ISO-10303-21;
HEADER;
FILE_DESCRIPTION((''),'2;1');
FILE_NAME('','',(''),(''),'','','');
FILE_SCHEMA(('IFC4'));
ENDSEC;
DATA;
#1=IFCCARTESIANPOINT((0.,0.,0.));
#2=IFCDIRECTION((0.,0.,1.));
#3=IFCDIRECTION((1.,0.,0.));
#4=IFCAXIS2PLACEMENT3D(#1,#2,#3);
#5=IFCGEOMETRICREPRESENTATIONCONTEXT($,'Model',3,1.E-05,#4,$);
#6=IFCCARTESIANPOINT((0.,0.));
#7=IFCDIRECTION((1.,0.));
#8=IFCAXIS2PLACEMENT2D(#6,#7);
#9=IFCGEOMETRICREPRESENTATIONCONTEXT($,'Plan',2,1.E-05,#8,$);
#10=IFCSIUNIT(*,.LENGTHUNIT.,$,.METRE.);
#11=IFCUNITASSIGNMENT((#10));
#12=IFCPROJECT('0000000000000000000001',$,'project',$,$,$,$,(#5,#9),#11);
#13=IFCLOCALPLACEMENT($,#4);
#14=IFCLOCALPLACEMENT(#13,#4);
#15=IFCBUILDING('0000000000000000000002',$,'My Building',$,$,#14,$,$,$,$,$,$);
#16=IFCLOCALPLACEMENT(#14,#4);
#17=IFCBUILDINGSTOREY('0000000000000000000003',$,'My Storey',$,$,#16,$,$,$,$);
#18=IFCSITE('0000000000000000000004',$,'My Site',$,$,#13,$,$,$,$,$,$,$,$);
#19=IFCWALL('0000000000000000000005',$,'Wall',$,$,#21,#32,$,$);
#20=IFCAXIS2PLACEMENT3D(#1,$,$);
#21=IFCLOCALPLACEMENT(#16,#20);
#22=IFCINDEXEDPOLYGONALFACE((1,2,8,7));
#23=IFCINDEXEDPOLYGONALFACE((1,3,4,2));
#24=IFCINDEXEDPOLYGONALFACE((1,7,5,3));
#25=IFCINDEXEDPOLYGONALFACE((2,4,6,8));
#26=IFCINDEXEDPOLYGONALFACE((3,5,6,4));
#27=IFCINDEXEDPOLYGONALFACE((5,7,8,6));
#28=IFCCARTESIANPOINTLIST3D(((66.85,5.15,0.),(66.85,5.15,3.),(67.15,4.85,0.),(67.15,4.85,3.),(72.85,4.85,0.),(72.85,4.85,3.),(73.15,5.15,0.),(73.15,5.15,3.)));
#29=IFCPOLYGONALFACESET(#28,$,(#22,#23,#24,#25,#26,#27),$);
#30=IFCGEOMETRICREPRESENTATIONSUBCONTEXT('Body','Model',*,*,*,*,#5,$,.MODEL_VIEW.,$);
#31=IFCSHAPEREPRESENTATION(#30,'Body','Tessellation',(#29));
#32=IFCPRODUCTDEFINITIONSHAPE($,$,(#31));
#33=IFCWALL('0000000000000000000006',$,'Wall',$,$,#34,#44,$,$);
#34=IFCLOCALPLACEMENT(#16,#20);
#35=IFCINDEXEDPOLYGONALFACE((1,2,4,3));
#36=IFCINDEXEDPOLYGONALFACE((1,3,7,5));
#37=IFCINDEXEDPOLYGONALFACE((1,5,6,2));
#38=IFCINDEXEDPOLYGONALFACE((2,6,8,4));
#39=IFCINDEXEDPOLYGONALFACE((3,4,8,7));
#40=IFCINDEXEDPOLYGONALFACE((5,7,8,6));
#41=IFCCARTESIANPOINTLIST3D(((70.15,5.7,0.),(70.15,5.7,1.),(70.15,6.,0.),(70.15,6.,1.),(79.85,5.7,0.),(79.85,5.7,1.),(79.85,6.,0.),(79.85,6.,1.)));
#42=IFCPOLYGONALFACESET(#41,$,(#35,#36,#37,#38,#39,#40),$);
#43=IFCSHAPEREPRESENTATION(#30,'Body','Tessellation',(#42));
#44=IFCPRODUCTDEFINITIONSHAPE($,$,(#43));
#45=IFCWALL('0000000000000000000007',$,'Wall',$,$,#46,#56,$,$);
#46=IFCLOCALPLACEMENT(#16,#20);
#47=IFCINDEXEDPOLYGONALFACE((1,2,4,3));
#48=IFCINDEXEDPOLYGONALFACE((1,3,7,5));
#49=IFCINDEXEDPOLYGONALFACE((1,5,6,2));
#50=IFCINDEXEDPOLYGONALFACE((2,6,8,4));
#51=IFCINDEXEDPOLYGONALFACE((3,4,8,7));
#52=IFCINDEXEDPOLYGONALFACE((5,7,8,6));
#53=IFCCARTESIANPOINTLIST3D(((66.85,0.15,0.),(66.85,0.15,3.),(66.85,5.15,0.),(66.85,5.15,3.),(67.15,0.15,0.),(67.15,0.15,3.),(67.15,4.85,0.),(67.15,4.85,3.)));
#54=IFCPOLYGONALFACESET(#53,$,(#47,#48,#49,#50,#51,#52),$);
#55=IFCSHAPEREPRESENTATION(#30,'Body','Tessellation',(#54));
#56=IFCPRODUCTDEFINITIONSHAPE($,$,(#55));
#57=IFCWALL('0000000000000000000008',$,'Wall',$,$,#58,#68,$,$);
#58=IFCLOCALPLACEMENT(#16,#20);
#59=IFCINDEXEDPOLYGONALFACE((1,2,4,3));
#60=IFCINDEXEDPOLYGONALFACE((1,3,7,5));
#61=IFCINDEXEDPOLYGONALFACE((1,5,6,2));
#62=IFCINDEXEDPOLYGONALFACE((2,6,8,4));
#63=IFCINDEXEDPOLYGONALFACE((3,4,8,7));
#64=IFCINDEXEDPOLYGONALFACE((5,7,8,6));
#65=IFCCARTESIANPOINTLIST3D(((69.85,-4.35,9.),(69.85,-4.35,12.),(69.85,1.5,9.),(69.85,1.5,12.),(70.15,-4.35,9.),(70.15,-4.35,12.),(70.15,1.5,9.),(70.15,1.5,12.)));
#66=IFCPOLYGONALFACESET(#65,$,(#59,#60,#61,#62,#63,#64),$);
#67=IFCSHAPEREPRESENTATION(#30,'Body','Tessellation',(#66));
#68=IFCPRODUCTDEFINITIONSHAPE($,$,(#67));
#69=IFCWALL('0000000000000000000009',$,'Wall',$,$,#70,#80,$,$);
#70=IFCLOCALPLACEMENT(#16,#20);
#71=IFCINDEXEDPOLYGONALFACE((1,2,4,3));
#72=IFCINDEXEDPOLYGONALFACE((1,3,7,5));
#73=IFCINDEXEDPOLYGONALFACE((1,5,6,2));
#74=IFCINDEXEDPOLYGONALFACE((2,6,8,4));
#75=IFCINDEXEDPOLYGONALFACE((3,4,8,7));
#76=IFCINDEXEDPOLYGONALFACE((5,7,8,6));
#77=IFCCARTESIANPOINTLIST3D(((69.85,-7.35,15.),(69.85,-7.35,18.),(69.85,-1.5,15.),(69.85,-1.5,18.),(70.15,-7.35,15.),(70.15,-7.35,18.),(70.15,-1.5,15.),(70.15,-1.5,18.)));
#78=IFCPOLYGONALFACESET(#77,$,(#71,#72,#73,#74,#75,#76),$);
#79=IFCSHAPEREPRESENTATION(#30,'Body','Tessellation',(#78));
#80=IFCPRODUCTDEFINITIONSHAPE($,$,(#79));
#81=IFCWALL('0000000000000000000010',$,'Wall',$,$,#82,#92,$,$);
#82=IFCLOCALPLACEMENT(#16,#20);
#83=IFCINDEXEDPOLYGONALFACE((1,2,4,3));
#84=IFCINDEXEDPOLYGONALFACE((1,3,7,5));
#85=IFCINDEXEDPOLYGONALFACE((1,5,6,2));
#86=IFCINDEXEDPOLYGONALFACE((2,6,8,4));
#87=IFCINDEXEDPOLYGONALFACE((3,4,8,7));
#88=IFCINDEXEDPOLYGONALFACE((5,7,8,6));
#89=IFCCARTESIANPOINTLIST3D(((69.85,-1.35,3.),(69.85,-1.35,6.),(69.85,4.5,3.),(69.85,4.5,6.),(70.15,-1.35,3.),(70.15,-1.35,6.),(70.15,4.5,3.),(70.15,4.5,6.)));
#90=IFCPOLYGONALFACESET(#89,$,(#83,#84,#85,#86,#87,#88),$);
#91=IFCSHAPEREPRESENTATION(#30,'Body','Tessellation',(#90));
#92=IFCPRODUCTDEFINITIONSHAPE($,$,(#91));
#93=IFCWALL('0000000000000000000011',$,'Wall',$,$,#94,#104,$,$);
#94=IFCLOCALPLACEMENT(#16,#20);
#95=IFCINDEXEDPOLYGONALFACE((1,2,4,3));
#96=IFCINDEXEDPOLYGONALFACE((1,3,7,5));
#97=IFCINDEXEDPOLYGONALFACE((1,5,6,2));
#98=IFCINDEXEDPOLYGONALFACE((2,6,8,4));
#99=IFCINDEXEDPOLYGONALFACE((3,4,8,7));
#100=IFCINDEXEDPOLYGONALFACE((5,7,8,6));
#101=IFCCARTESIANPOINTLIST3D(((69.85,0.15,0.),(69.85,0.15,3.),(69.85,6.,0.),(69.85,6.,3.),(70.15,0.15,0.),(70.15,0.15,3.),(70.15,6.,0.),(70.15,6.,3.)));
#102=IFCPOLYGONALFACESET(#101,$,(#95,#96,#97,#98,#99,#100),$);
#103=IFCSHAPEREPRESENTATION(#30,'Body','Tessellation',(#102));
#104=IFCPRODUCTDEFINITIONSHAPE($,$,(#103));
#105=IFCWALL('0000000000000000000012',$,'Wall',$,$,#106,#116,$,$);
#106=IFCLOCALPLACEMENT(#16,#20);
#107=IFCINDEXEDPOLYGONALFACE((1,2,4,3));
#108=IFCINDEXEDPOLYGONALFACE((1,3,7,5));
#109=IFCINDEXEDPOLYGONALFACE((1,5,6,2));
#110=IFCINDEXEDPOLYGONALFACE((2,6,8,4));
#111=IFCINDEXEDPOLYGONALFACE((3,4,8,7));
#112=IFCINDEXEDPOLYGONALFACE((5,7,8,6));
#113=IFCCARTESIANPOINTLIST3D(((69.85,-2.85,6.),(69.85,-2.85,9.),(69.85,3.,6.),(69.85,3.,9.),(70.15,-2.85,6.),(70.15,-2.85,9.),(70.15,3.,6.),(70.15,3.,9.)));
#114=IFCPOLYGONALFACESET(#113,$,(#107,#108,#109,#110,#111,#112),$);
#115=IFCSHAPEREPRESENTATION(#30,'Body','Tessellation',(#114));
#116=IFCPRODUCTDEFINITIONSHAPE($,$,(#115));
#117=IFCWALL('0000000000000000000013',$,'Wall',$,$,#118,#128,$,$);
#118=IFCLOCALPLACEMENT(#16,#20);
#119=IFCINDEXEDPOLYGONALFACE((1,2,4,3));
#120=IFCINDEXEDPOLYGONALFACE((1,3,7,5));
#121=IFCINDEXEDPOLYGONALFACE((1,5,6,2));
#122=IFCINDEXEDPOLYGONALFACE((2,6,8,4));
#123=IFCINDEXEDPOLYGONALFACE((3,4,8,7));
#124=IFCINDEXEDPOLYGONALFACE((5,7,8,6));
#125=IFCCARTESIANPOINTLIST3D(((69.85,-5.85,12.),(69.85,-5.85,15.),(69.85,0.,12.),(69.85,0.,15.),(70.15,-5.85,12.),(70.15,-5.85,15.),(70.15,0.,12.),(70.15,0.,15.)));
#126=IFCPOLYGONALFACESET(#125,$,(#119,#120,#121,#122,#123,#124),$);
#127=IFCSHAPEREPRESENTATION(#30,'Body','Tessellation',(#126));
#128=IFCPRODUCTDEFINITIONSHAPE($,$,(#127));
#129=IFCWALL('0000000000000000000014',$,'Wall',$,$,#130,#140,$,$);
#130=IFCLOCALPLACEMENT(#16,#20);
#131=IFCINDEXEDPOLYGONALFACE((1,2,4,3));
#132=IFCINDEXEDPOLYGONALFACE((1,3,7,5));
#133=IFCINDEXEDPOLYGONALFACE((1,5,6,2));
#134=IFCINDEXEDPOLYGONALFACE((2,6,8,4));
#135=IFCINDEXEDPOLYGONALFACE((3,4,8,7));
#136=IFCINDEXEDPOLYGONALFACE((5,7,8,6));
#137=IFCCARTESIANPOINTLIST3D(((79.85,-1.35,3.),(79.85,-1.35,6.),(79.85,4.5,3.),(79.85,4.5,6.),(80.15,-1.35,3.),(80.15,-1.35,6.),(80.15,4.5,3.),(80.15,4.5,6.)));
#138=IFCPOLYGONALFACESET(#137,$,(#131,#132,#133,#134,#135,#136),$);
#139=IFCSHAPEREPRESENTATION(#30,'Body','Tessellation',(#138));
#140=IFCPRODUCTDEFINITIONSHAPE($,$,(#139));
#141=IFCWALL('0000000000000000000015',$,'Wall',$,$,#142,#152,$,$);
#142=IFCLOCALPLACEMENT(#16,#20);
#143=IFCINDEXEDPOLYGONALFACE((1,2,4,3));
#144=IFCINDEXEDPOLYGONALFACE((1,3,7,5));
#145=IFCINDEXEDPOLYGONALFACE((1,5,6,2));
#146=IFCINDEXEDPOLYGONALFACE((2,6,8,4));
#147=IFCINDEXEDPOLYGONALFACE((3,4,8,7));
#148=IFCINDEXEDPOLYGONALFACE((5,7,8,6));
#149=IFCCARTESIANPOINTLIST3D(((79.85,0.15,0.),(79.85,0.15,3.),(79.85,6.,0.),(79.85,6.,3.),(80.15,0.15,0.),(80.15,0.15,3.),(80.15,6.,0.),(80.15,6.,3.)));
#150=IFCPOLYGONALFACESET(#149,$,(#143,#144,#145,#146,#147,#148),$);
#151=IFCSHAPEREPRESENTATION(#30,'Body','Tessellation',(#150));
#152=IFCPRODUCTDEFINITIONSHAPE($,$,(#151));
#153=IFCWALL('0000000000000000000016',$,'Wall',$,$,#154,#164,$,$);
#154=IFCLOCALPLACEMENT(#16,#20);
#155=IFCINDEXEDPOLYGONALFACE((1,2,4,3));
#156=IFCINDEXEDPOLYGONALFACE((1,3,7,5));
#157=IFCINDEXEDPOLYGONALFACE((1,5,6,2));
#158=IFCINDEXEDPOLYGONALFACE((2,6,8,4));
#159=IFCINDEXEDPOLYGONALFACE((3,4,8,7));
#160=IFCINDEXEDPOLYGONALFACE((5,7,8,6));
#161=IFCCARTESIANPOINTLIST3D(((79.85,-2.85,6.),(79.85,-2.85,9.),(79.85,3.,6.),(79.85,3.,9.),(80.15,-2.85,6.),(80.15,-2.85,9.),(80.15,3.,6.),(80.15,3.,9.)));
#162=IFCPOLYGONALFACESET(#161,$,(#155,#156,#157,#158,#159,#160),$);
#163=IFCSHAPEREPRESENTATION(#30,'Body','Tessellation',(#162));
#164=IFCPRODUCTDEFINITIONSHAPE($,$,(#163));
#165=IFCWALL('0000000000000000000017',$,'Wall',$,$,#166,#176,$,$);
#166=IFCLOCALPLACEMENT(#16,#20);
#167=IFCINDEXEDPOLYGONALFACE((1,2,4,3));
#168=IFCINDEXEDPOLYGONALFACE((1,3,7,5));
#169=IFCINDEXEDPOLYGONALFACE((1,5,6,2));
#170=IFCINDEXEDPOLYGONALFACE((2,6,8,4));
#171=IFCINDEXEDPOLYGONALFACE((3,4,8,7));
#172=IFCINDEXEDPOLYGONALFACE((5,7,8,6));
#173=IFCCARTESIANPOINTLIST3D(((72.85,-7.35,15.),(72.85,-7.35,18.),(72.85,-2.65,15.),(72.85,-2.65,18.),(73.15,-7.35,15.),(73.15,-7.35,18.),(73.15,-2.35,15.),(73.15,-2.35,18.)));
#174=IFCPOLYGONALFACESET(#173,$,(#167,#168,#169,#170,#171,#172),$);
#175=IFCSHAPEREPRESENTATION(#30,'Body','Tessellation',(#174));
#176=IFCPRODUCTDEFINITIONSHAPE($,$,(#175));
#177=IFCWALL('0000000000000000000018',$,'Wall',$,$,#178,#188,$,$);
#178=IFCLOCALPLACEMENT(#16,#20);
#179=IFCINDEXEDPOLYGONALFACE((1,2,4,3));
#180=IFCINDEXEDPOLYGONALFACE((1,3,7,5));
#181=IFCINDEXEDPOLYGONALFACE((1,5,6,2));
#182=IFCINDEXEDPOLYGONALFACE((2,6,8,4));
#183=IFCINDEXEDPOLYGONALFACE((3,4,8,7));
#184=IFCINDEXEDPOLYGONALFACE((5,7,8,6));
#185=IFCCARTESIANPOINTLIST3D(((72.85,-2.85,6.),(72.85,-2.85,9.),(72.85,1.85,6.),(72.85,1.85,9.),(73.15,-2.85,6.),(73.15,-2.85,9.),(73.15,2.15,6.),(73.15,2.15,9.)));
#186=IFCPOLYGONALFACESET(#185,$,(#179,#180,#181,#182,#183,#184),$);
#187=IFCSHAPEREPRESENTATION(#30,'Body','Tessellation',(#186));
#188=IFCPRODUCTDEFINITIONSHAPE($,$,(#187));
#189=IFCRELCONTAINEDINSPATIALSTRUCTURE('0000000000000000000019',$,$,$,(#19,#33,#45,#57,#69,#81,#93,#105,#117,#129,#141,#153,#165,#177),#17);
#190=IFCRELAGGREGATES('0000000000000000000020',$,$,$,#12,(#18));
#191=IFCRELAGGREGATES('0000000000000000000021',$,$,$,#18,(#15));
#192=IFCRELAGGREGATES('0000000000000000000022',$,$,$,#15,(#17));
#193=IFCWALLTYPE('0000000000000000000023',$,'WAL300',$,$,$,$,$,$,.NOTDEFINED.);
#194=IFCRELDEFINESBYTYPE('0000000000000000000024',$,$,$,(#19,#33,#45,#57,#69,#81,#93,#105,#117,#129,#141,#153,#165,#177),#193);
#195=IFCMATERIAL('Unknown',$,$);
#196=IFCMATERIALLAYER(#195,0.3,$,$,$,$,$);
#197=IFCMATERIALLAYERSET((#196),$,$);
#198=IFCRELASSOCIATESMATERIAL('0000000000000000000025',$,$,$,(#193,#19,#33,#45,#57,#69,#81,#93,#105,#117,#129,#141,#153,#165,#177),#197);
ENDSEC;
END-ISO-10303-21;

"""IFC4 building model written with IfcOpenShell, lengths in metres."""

from ifc_helpers import new_model, si_unit, frame, origin_with_axes, origin_2d_with_axis, place, context, subcontext, project, spatial, line, indexed_curve, outline, extrude, material, layer, layer_set, layer_usage, type_object, element, save


model = new_model("IFC4")

# Units and contexts
model_context = context("Model", 3, precision=1e-05, world=origin_with_axes())
plan_context = context("Plan", 2, precision=1e-05, world=origin_2d_with_axis())
body_context = subcontext(model_context, "Body", "Model", "MODEL_VIEW")
ifc_project = project(units=[si_unit("LENGTHUNIT", "METRE")], contexts=[model_context, plan_context])

# Site, building, storey
site_placement = place(None, origin_with_axes())
site = spatial("IfcSite", under=ifc_project, at=site_placement, Name="My Site")
building_placement = place(site_placement, origin_with_axes())
building = spatial("IfcBuilding", under=site, at=building_placement, Name="My Building")
storey_placement = place(building_placement, origin_with_axes())
storey = spatial("IfcBuildingStorey", under=building, at=storey_placement, Name="My Storey")

# Walls
ifc_material = material(Name="Unknown")
ifc_layer = layer(ifc_material, 0.3)
ifc_layer_set = layer_set([ifc_layer])
ifc_layer_usage_1 = layer_usage(ifc_layer_set, "AXIS2", "POSITIVE", -0.15)
wall_type = type_object("IfcWallType", Name="WAL300", PredefinedType="NOTDEFINED", material=ifc_layer_set)
wall_1_placement = place(storey_placement, frame((67.0, 5.0, 0.0), z_axis=(0.0, 0.0, 1.0), x_axis=(1.0, 0.0, 0.0)))
element("IfcWall", 1, at=wall_1_placement, inside=storey, type_object=wall_type, material=ifc_layer_usage_1, Name="Wall", context=body_context, shape_type="SweptSolid", body=[
    extrude(outline(indexed_curve([(0.15, -0.15), (-0.15, 0.15), (6.15, 0.15), (5.85, -0.15)], segments=[line(1, 2, 3, 4, 1)])), origin_with_axes(), (0.0, 0.0, 1.0), 3.0),
])
ifc_layer_usage_2 = layer_usage(ifc_layer_set, "AXIS2", "POSITIVE", -0.3)
wall_2_placement = place(storey_placement, frame((70.15, 6.0, 0.0), z_axis=(0.0, 0.0, 1.0), x_axis=(1.0, 0.0, 0.0)))
element("IfcWall", 2, at=wall_2_placement, inside=storey, type_object=wall_type, material=ifc_layer_usage_2, Name="Wall", context=body_context, shape_type="SweptSolid", body=[
    extrude(outline(indexed_curve([(0.0, -0.3), (0.0, 0.0), (9.7, 0.0), (9.7, -0.3)], segments=[line(1, 2, 3, 4, 1)])), origin_with_axes(), (0.0, 0.0, 1.0), 1.0),
])
ifc_layer_usage_3 = layer_usage(ifc_layer_set, "AXIS2", "POSITIVE", -0.15)
wall_3_placement = place(storey_placement, frame((67.0, 5.0, 0.0), z_axis=(0.0, 0.0, 1.0), x_axis=(0.0, -1.0, 0.0)))
element("IfcWall", 3, at=wall_3_placement, inside=storey, type_object=wall_type, material=ifc_layer_usage_3, Name="Wall", context=body_context, shape_type="SweptSolid", body=[
    extrude(outline(indexed_curve([(-0.15, -0.15), (0.15, 0.15), (4.85, 0.15), (4.85, -0.15)], segments=[line(1, 2, 3, 4, 1)])), origin_with_axes(), (0.0, 0.0, 1.0), 3.0),
])
ifc_layer_usage_4 = layer_usage(ifc_layer_set, "AXIS2", "POSITIVE", -0.15)
wall_4_placement = place(storey_placement, frame((70.0, 1.5, 9.0), z_axis=(0.0, 0.0, 1.0), x_axis=(0.0, -1.0, 0.0)))
element("IfcWall", 4, at=wall_4_placement, inside=storey, type_object=wall_type, material=ifc_layer_usage_4, Name="Wall", context=body_context, shape_type="SweptSolid", body=[
    extrude(outline(indexed_curve([(0.0, -0.15), (0.0, 0.15), (5.85, 0.15), (5.85, -0.15)], segments=[line(1, 2, 3, 4, 1)])), origin_with_axes(), (0.0, 0.0, 1.0), 3.0),
])
ifc_layer_usage_5 = layer_usage(ifc_layer_set, "AXIS2", "POSITIVE", -0.15)
wall_5_placement = place(storey_placement, frame((70.0, -1.5, 15.0), z_axis=(0.0, 0.0, 1.0), x_axis=(0.0, -1.0, 0.0)))
element("IfcWall", 5, at=wall_5_placement, inside=storey, type_object=wall_type, material=ifc_layer_usage_5, Name="Wall", context=body_context, shape_type="SweptSolid", body=[
    extrude(outline(indexed_curve([(0.0, -0.15), (0.0, 0.15), (5.85, 0.15), (5.85, -0.15)], segments=[line(1, 2, 3, 4, 1)])), origin_with_axes(), (0.0, 0.0, 1.0), 3.0),
])
ifc_layer_usage_6 = layer_usage(ifc_layer_set, "AXIS2", "POSITIVE", -0.15)
wall_6_placement = place(storey_placement, frame((70.0, 4.5, 3.0), z_axis=(0.0, 0.0, 1.0), x_axis=(0.0, -1.0, 0.0)))
element("IfcWall", 6, at=wall_6_placement, inside=storey, type_object=wall_type, material=ifc_layer_usage_6, Name="Wall", context=body_context, shape_type="SweptSolid", body=[
    extrude(outline(indexed_curve([(0.0, -0.15), (0.0, 0.15), (5.85, 0.15), (5.85, -0.15)], segments=[line(1, 2, 3, 4, 1)])), origin_with_axes(), (0.0, 0.0, 1.0), 3.0),
])
ifc_layer_usage_7 = layer_usage(ifc_layer_set, "AXIS2", "POSITIVE", -0.15)
wall_7_placement = place(storey_placement, frame((70.0, 6.0, 0.0), z_axis=(0.0, 0.0, 1.0), x_axis=(0.0, -1.0, 0.0)))
element("IfcWall", 7, at=wall_7_placement, inside=storey, type_object=wall_type, material=ifc_layer_usage_7, Name="Wall", context=body_context, shape_type="SweptSolid", body=[
    extrude(outline(indexed_curve([(0.0, -0.15), (0.0, 0.15), (5.85, 0.15), (5.85, -0.15)], segments=[line(1, 2, 3, 4, 1)])), origin_with_axes(), (0.0, 0.0, 1.0), 3.0),
])
ifc_layer_usage_8 = layer_usage(ifc_layer_set, "AXIS2", "POSITIVE", -0.15)
wall_8_placement = place(storey_placement, frame((70.0, 3.0, 6.0), z_axis=(0.0, 0.0, 1.0), x_axis=(0.0, -1.0, 0.0)))
element("IfcWall", 8, at=wall_8_placement, inside=storey, type_object=wall_type, material=ifc_layer_usage_8, Name="Wall", context=body_context, shape_type="SweptSolid", body=[
    extrude(outline(indexed_curve([(0.0, -0.15), (0.0, 0.15), (5.85, 0.15), (5.85, -0.15)], segments=[line(1, 2, 3, 4, 1)])), origin_with_axes(), (0.0, 0.0, 1.0), 3.0),
])
ifc_layer_usage_9 = layer_usage(ifc_layer_set, "AXIS2", "POSITIVE", -0.15)
wall_9_placement = place(storey_placement, frame((70.0, 0.0, 12.0), z_axis=(0.0, 0.0, 1.0), x_axis=(0.0, -1.0, 0.0)))
element("IfcWall", 9, at=wall_9_placement, inside=storey, type_object=wall_type, material=ifc_layer_usage_9, Name="Wall", context=body_context, shape_type="SweptSolid", body=[
    extrude(outline(indexed_curve([(0.0, -0.15), (0.0, 0.15), (5.85, 0.15), (5.85, -0.15)], segments=[line(1, 2, 3, 4, 1)])), origin_with_axes(), (0.0, 0.0, 1.0), 3.0),
])
ifc_layer_usage_10 = layer_usage(ifc_layer_set, "AXIS2", "POSITIVE", -0.15)
wall_10_placement = place(storey_placement, frame((80.0, -1.5, 3.0), z_axis=(0.0, 0.0, 1.0), x_axis=(0.0, 1.0, 0.0)))
element("IfcWall", 10, at=wall_10_placement, inside=storey, type_object=wall_type, material=ifc_layer_usage_10, Name="Wall", context=body_context, shape_type="SweptSolid", body=[
    extrude(outline(indexed_curve([(0.15, -0.15), (0.15, 0.15), (6.0, 0.15), (6.0, -0.15)], segments=[line(1, 2, 3, 4, 1)])), origin_with_axes(), (0.0, 0.0, 1.0), 3.0),
])
ifc_layer_usage_11 = layer_usage(ifc_layer_set, "AXIS2", "POSITIVE", -0.15)
wall_11_placement = place(storey_placement, frame((80.0, 0.0, 0.0), z_axis=(0.0, 0.0, 1.0), x_axis=(0.0, 1.0, 0.0)))
element("IfcWall", 11, at=wall_11_placement, inside=storey, type_object=wall_type, material=ifc_layer_usage_11, Name="Wall", context=body_context, shape_type="SweptSolid", body=[
    extrude(outline(indexed_curve([(0.15, -0.15), (0.15, 0.15), (6.0, 0.15), (6.0, -0.15)], segments=[line(1, 2, 3, 4, 1)])), origin_with_axes(), (0.0, 0.0, 1.0), 3.0),
])
ifc_layer_usage_12 = layer_usage(ifc_layer_set, "AXIS2", "POSITIVE", -0.15)
wall_12_placement = place(storey_placement, frame((80.0, -3.0, 6.0), z_axis=(0.0, 0.0, 1.0), x_axis=(0.0, 1.0, 0.0)))
element("IfcWall", 12, at=wall_12_placement, inside=storey, type_object=wall_type, material=ifc_layer_usage_12, Name="Wall", context=body_context, shape_type="SweptSolid", body=[
    extrude(outline(indexed_curve([(0.15, -0.15), (0.15, 0.15), (6.0, 0.15), (6.0, -0.15)], segments=[line(1, 2, 3, 4, 1)])), origin_with_axes(), (0.0, 0.0, 1.0), 3.0),
])
ifc_layer_usage_13 = layer_usage(ifc_layer_set, "AXIS2", "POSITIVE", -0.15)
wall_13_placement = place(storey_placement, frame((73.0, -7.5, 15.0), z_axis=(0.0, 0.0, 1.0), x_axis=(0.0, 1.0, 0.0)))
element("IfcWall", 13, at=wall_13_placement, inside=storey, type_object=wall_type, material=ifc_layer_usage_13, Name="Wall", context=body_context, shape_type="SweptSolid", body=[
    extrude(outline(indexed_curve([(0.15, -0.15), (0.15, 0.15), (4.85, 0.15), (5.15, -0.15)], segments=[line(1, 2, 3, 4, 1)])), origin_with_axes(), (0.0, 0.0, 1.0), 3.0),
])
ifc_layer_usage_14 = layer_usage(ifc_layer_set, "AXIS2", "POSITIVE", -0.15)
wall_14_placement = place(storey_placement, frame((73.0, -3.0, 6.0), z_axis=(0.0, 0.0, 1.0), x_axis=(0.0, 1.0, 0.0)))
element("IfcWall", 14, at=wall_14_placement, inside=storey, type_object=wall_type, material=ifc_layer_usage_14, Name="Wall", context=body_context, shape_type="SweptSolid", body=[
    extrude(outline(indexed_curve([(0.15, -0.15), (0.15, 0.15), (4.85, 0.15), (5.15, -0.15)], segments=[line(1, 2, 3, 4, 1)])), origin_with_axes(), (0.0, 0.0, 1.0), 3.0),
])

save(model, "model.ifc")
